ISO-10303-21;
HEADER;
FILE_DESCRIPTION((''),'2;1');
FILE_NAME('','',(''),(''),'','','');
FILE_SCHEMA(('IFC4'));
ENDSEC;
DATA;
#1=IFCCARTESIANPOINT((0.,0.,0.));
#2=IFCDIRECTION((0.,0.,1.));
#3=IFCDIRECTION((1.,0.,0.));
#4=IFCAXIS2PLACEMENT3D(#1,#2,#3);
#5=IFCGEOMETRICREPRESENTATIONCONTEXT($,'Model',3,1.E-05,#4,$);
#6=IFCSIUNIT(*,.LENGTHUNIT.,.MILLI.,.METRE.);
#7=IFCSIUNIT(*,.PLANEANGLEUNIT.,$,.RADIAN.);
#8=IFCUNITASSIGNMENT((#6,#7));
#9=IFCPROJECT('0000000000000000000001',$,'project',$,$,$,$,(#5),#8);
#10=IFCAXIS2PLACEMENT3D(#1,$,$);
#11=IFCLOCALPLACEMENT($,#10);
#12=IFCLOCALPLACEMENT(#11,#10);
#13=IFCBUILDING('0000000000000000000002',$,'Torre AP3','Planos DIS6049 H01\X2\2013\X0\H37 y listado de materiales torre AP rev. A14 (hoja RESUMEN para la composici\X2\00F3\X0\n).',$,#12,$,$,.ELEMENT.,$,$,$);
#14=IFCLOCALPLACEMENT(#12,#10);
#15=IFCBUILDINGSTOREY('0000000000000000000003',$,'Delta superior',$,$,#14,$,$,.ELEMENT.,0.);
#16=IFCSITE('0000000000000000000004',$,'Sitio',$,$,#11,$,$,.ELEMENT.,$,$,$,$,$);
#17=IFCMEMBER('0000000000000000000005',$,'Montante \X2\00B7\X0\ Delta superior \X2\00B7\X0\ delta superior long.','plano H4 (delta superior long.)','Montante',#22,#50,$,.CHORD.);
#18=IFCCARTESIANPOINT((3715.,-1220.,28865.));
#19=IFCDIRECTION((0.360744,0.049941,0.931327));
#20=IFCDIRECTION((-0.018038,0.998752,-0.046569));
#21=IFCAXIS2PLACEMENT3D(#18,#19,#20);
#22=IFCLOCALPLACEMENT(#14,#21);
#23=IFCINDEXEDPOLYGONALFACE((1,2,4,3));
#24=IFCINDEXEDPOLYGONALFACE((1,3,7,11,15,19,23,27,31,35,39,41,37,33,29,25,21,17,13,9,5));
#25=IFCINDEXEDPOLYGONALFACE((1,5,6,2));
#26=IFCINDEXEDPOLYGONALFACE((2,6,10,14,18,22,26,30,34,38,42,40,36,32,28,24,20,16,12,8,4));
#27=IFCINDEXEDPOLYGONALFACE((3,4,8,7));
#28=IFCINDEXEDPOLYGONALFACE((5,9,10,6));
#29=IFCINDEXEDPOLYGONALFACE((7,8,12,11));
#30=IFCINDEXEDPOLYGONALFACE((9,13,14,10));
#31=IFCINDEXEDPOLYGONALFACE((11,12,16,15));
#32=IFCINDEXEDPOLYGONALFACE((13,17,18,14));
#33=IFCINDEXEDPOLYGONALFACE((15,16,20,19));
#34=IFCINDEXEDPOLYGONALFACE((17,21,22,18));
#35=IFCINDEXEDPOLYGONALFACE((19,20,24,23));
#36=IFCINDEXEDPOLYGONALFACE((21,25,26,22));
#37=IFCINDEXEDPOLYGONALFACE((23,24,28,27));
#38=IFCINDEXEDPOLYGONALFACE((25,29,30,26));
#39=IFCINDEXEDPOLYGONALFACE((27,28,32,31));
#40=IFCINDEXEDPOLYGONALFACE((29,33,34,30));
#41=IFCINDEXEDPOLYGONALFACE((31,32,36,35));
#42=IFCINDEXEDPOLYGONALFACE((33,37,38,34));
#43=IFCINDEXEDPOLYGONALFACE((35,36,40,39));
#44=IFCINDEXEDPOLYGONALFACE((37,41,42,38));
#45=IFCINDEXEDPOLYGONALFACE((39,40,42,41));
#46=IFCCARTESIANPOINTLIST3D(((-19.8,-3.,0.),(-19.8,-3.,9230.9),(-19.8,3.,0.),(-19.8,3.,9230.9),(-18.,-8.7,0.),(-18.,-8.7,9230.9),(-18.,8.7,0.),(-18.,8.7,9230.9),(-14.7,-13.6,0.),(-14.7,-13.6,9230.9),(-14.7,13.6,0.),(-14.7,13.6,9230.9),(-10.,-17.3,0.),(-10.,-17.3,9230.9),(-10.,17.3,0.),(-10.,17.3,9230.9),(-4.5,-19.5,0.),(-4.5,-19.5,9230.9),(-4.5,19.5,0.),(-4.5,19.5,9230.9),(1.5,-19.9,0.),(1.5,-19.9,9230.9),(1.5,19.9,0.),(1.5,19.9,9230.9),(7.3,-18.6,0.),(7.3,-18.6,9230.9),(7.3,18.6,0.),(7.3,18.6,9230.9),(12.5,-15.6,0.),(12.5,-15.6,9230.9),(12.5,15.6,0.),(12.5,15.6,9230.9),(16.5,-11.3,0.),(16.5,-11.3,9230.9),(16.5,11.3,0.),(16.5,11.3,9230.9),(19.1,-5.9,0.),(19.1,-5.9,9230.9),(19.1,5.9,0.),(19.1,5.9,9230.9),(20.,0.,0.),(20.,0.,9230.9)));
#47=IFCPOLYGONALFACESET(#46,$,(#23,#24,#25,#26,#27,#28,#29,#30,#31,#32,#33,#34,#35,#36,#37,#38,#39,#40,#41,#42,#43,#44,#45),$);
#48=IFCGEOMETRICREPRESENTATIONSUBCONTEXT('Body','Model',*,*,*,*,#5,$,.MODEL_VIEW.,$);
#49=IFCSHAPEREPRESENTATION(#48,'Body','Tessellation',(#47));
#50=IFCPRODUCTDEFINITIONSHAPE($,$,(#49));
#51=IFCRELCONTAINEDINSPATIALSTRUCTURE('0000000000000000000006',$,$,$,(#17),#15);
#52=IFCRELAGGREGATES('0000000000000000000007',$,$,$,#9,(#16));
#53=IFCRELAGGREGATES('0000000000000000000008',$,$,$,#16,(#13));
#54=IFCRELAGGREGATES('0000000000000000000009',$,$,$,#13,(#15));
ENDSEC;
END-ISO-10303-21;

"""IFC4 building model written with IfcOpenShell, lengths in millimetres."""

from ifc_helpers import new_model, si_unit, frame, origin, origin_with_axes, place, context, subcontext, project, spatial, circle, extrude, element, save


model = new_model("IFC4")

# Units and contexts
model_context = context("Model", 3, precision=1e-05, world=origin_with_axes())
body_context = subcontext(model_context, "Body", "Model", "MODEL_VIEW")
ifc_project = project(units=[si_unit("LENGTHUNIT", "METRE", prefix="MILLI"), si_unit("PLANEANGLEUNIT", "RADIAN")], contexts=[model_context])

# Site, building, storey
site_placement = place(None, origin())
site = spatial("IfcSite", under=ifc_project, at=site_placement, Name="Sitio", CompositionType="ELEMENT")
building_placement = place(site_placement, origin())
building = spatial("IfcBuilding", under=site, at=building_placement, Name="Torre AP3", Description="Planos DIS6049 H01–H37 y listado de materiales torre AP rev. A14 (hoja RESUMEN para la composición).", CompositionType="ELEMENT")
storey_placement = place(building_placement, origin())
storey = spatial("IfcBuildingStorey", under=building, at=storey_placement, Name="Delta superior", CompositionType="ELEMENT", Elevation=0.0)

# Member
for number, where, z_axis, x_axis, name in (
    (1, (3715.0, -1220.0, 28865.0), (0.360744, 0.049941, 0.931327), (-0.018038, 0.998752, -0.046569), "Montante · Delta superior · delta superior long."),
):
    element("IfcMember", number, at=place(storey_placement, frame(where, z_axis=z_axis, x_axis=x_axis)), inside=storey, Name=name, Description="plano H4 (delta superior long.)", ObjectType="Montante", PredefinedType="CHORD", context=body_context, shape_type="SweptSolid", body=[
        extrude(circle(Radius=20.0), None, (0.0, 0.0, 1.0), 9230.9),
    ])

save(model, "model.ifc")
